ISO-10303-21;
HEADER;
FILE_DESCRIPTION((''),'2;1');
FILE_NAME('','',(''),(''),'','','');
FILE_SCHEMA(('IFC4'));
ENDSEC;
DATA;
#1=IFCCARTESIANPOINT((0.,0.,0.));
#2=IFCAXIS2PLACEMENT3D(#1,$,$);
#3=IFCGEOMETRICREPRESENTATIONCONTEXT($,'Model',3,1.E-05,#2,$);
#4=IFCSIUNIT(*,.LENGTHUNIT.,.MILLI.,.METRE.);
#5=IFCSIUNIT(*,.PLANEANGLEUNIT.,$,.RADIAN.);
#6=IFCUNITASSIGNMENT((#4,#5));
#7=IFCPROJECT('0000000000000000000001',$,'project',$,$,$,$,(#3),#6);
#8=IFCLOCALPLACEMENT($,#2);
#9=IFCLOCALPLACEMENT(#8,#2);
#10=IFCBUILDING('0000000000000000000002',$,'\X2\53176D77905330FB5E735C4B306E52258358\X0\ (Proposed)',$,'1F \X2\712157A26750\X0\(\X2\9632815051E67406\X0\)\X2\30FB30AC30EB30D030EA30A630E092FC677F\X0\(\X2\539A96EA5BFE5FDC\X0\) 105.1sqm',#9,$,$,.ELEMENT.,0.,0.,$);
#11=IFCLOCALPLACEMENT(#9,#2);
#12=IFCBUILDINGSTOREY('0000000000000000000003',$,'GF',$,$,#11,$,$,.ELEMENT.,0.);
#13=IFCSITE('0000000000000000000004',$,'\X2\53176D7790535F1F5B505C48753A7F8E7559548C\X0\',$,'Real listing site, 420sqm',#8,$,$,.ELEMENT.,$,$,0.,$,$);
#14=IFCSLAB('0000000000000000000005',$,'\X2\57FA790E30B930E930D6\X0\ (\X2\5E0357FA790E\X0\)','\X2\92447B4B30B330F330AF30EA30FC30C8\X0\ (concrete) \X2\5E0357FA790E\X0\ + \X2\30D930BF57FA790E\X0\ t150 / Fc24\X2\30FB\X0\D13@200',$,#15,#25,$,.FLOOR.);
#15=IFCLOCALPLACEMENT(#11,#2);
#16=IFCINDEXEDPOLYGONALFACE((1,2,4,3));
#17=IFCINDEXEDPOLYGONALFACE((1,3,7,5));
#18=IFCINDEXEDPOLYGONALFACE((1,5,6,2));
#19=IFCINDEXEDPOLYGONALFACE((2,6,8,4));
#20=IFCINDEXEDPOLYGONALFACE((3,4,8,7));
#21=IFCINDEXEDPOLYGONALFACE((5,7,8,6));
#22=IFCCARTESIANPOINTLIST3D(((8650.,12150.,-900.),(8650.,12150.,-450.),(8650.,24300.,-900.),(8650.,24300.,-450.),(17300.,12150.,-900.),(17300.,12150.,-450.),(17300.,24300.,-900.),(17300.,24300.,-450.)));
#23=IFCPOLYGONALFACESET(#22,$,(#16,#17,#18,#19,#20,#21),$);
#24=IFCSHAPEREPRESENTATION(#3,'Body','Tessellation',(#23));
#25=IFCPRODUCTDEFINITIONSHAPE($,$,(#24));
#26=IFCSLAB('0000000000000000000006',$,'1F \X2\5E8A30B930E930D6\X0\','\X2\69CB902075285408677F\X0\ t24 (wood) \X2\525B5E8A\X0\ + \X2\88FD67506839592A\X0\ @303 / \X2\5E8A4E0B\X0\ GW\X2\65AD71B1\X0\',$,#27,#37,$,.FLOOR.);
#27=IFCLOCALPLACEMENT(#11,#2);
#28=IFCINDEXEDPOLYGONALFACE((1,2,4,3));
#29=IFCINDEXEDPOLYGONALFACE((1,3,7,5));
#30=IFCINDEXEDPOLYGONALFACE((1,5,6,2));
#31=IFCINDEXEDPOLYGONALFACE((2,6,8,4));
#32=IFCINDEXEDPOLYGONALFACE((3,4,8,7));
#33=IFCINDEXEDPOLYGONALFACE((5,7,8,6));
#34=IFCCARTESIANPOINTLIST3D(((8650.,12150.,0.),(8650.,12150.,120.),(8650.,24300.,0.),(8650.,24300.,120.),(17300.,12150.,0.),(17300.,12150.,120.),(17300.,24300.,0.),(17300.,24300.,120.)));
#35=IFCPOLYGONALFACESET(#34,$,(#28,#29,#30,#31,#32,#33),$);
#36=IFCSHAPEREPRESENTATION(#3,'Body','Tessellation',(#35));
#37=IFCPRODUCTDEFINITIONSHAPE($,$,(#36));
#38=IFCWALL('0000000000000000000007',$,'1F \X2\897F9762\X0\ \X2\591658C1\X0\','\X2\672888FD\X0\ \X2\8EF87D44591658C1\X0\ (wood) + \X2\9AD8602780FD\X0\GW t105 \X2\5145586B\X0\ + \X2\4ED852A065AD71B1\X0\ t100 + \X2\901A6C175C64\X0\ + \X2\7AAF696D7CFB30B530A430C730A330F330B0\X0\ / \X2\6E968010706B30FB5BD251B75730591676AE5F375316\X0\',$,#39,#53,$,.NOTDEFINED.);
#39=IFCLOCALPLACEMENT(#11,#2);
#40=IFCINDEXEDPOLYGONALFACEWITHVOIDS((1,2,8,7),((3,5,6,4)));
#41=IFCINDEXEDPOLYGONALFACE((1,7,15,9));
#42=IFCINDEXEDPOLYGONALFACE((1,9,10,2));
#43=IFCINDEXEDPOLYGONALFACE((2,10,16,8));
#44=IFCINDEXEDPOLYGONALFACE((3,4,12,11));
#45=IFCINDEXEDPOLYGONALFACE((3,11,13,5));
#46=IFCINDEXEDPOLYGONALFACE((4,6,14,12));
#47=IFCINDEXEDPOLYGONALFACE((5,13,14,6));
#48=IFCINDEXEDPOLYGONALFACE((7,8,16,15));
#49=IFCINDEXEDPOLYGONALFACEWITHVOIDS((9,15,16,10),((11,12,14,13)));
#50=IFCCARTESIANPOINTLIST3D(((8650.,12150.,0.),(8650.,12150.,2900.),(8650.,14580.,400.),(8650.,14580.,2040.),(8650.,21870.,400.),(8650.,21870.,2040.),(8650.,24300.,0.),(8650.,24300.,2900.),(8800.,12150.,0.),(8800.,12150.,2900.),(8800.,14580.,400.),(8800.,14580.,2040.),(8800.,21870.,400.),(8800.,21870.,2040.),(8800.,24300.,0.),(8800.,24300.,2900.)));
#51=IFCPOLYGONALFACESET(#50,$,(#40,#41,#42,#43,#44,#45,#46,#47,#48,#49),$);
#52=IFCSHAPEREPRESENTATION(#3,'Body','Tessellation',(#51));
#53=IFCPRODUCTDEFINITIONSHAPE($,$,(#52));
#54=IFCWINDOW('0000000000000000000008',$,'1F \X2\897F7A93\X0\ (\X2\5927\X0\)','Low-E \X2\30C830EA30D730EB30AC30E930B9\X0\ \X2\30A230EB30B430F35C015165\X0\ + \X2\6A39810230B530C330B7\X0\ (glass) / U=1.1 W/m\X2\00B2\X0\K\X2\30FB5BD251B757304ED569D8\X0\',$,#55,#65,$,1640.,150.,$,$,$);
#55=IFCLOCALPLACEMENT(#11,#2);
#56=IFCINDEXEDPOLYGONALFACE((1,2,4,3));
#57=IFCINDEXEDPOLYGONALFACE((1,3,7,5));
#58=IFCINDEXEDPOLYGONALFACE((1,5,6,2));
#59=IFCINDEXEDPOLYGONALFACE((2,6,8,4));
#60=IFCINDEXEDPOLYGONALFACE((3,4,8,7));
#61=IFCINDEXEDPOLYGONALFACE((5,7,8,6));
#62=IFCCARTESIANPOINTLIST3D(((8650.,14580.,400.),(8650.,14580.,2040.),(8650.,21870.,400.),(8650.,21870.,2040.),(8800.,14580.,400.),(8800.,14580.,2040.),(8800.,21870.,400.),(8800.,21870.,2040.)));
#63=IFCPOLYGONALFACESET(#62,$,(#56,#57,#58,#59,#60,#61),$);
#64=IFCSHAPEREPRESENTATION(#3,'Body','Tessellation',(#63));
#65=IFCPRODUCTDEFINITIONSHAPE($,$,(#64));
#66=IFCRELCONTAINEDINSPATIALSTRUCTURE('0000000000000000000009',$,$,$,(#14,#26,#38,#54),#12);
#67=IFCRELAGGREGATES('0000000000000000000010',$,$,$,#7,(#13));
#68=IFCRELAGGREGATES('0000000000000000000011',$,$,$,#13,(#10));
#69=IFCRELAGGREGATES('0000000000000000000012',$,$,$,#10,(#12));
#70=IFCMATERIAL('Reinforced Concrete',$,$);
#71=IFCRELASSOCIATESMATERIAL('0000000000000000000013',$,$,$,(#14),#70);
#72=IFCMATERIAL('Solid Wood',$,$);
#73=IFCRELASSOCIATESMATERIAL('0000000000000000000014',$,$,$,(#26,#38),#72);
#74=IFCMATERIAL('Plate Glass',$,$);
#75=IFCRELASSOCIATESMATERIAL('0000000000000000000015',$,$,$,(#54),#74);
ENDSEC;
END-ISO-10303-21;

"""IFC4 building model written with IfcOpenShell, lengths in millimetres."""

from ifc_helpers import new_model, si_unit, frame, frame_2d, origin, place, context, project, spatial, rectangle, extrude, material, element, fill, save


model = new_model("IFC4")

# Units and contexts
model_context = context("Model", 3, precision=1e-05, world=origin())
ifc_project = project(units=[si_unit("LENGTHUNIT", "METRE", prefix="MILLI"), si_unit("PLANEANGLEUNIT", "RADIAN")], contexts=[model_context])

# Site, building, storey
site_placement = place(None, origin())
site = spatial("IfcSite", under=ifc_project, at=site_placement, Name="北海道弟子屈町美留和", ObjectType="Real listing site, 420sqm", CompositionType="ELEMENT", RefElevation=0.0)
building_placement = place(site_placement, origin())
building = spatial("IfcBuilding", under=site, at=building_placement, Name="北海道・平屋の別荘 (Proposed)", ObjectType="1F 無垢材(防腐処理)・ガルバリウム鋼板(厚雪対応) 105.1sqm", CompositionType="ELEMENT", ElevationOfRefHeight=0.0, ElevationOfTerrain=0.0)
storey_placement = place(building_placement, origin())
storey = spatial("IfcBuildingStorey", under=building, at=storey_placement, Name="GF", CompositionType="ELEMENT", Elevation=0.0)

# Shared definitions
ifc_material_1 = material(Name="Solid Wood")

# Slabs
ifc_material_2 = material(Name="Reinforced Concrete")
slab_1_placement = place(storey_placement, frame((4325.0, 6075.0, -450.0)))
element("IfcSlab", 1, at=slab_1_placement, inside=storey, material=ifc_material_2, Name="基礎スラブ (布基礎)", Description="鉄筋コンクリート (concrete) 布基礎 + ベタ基礎 t150 / Fc24・D13@200", PredefinedType="FLOOR", context=model_context, shape_type="SweptSolid", body=[
    extrude(rectangle(XDim=8650.0, YDim=12150.0, at=frame_2d((4325.0, 6075.0))), frame((4325.0, 6075.0, -450.0)), (0.0, 0.0, 1.0), 450.0),
])
slab_2_placement = place(storey_placement, frame((4325.0, 6075.0, 0.0)))
element("IfcSlab", 2, at=slab_2_placement, inside=storey, material=ifc_material_1, Name="1F 床スラブ", Description="構造用合板 t24 (wood) 剛床 + 製材根太 @303 / 床下 GW断熱", PredefinedType="FLOOR", context=model_context, shape_type="SweptSolid", body=[
    extrude(rectangle(XDim=8650.0, YDim=12150.0, at=frame_2d((4325.0, 6075.0))), frame((4325.0, 6075.0, 0.0)), (0.0, 0.0, 1.0), 120.0),
])

# Shared definitions
ifc_material_3 = material(Name="Plate Glass")

# Wall, opening, window
wall_1_placement = place(storey_placement, frame((4325.0, 6075.0, 0.0)))
wall_1 = element("IfcWall", 3, at=wall_1_placement, inside=storey, material=ifc_material_1, Name="1F 西面 外壁", Description="木製 軸組外壁 (wood) + 高性能GW t105 充填 + 付加断熱 t100 + 通気層 + 窯業系サイディング / 準耐火・寒冷地外皮強化", PredefinedType="NOTDEFINED", context=model_context, shape_type="SweptSolid", body=[
    extrude(rectangle(XDim=150.0, YDim=12150.0, at=frame_2d((75.0, 6075.0))), frame((4325.0, 6075.0, 0.0)), (0.0, 0.0, 1.0), 2900.0),
])
opening_1_placement = place(storey_placement, frame((4325.0, 7290.0, 200.0)))
opening_1 = element("IfcOpeningElement", 4, at=opening_1_placement, cuts=wall_1, PredefinedType="NOTDEFINED", context=model_context, shape_type="SweptSolid", body=[
    extrude(rectangle(XDim=150.0, YDim=7290.0, at=frame_2d((75.0, 3645.0))), frame((4325.0, 7290.0, 200.0)), (0.0, 0.0, 1.0), 1640.0),
])
window_1_placement = place(storey_placement, frame((4325.0, 7290.0, 200.0)))
window_1 = element("IfcWindow", 5, at=window_1_placement, inside=storey, material=ifc_material_3, Name="1F 西窓 (大)", Description="Low-E トリプルガラス アルゴン封入 + 樹脂サッシ (glass) / U=1.1 W/m²K・寒冷地仕様", OverallHeight=1640.0, OverallWidth=150.0, context=model_context, shape_type="SweptSolid", body=[
    extrude(rectangle(XDim=150.0, YDim=7290.0, at=frame_2d((75.0, 3645.0))), frame((4325.0, 7290.0, 200.0)), (0.0, 0.0, 1.0), 1640.0),
])
fill(opening_1, window_1)

save(model, "model.ifc")
